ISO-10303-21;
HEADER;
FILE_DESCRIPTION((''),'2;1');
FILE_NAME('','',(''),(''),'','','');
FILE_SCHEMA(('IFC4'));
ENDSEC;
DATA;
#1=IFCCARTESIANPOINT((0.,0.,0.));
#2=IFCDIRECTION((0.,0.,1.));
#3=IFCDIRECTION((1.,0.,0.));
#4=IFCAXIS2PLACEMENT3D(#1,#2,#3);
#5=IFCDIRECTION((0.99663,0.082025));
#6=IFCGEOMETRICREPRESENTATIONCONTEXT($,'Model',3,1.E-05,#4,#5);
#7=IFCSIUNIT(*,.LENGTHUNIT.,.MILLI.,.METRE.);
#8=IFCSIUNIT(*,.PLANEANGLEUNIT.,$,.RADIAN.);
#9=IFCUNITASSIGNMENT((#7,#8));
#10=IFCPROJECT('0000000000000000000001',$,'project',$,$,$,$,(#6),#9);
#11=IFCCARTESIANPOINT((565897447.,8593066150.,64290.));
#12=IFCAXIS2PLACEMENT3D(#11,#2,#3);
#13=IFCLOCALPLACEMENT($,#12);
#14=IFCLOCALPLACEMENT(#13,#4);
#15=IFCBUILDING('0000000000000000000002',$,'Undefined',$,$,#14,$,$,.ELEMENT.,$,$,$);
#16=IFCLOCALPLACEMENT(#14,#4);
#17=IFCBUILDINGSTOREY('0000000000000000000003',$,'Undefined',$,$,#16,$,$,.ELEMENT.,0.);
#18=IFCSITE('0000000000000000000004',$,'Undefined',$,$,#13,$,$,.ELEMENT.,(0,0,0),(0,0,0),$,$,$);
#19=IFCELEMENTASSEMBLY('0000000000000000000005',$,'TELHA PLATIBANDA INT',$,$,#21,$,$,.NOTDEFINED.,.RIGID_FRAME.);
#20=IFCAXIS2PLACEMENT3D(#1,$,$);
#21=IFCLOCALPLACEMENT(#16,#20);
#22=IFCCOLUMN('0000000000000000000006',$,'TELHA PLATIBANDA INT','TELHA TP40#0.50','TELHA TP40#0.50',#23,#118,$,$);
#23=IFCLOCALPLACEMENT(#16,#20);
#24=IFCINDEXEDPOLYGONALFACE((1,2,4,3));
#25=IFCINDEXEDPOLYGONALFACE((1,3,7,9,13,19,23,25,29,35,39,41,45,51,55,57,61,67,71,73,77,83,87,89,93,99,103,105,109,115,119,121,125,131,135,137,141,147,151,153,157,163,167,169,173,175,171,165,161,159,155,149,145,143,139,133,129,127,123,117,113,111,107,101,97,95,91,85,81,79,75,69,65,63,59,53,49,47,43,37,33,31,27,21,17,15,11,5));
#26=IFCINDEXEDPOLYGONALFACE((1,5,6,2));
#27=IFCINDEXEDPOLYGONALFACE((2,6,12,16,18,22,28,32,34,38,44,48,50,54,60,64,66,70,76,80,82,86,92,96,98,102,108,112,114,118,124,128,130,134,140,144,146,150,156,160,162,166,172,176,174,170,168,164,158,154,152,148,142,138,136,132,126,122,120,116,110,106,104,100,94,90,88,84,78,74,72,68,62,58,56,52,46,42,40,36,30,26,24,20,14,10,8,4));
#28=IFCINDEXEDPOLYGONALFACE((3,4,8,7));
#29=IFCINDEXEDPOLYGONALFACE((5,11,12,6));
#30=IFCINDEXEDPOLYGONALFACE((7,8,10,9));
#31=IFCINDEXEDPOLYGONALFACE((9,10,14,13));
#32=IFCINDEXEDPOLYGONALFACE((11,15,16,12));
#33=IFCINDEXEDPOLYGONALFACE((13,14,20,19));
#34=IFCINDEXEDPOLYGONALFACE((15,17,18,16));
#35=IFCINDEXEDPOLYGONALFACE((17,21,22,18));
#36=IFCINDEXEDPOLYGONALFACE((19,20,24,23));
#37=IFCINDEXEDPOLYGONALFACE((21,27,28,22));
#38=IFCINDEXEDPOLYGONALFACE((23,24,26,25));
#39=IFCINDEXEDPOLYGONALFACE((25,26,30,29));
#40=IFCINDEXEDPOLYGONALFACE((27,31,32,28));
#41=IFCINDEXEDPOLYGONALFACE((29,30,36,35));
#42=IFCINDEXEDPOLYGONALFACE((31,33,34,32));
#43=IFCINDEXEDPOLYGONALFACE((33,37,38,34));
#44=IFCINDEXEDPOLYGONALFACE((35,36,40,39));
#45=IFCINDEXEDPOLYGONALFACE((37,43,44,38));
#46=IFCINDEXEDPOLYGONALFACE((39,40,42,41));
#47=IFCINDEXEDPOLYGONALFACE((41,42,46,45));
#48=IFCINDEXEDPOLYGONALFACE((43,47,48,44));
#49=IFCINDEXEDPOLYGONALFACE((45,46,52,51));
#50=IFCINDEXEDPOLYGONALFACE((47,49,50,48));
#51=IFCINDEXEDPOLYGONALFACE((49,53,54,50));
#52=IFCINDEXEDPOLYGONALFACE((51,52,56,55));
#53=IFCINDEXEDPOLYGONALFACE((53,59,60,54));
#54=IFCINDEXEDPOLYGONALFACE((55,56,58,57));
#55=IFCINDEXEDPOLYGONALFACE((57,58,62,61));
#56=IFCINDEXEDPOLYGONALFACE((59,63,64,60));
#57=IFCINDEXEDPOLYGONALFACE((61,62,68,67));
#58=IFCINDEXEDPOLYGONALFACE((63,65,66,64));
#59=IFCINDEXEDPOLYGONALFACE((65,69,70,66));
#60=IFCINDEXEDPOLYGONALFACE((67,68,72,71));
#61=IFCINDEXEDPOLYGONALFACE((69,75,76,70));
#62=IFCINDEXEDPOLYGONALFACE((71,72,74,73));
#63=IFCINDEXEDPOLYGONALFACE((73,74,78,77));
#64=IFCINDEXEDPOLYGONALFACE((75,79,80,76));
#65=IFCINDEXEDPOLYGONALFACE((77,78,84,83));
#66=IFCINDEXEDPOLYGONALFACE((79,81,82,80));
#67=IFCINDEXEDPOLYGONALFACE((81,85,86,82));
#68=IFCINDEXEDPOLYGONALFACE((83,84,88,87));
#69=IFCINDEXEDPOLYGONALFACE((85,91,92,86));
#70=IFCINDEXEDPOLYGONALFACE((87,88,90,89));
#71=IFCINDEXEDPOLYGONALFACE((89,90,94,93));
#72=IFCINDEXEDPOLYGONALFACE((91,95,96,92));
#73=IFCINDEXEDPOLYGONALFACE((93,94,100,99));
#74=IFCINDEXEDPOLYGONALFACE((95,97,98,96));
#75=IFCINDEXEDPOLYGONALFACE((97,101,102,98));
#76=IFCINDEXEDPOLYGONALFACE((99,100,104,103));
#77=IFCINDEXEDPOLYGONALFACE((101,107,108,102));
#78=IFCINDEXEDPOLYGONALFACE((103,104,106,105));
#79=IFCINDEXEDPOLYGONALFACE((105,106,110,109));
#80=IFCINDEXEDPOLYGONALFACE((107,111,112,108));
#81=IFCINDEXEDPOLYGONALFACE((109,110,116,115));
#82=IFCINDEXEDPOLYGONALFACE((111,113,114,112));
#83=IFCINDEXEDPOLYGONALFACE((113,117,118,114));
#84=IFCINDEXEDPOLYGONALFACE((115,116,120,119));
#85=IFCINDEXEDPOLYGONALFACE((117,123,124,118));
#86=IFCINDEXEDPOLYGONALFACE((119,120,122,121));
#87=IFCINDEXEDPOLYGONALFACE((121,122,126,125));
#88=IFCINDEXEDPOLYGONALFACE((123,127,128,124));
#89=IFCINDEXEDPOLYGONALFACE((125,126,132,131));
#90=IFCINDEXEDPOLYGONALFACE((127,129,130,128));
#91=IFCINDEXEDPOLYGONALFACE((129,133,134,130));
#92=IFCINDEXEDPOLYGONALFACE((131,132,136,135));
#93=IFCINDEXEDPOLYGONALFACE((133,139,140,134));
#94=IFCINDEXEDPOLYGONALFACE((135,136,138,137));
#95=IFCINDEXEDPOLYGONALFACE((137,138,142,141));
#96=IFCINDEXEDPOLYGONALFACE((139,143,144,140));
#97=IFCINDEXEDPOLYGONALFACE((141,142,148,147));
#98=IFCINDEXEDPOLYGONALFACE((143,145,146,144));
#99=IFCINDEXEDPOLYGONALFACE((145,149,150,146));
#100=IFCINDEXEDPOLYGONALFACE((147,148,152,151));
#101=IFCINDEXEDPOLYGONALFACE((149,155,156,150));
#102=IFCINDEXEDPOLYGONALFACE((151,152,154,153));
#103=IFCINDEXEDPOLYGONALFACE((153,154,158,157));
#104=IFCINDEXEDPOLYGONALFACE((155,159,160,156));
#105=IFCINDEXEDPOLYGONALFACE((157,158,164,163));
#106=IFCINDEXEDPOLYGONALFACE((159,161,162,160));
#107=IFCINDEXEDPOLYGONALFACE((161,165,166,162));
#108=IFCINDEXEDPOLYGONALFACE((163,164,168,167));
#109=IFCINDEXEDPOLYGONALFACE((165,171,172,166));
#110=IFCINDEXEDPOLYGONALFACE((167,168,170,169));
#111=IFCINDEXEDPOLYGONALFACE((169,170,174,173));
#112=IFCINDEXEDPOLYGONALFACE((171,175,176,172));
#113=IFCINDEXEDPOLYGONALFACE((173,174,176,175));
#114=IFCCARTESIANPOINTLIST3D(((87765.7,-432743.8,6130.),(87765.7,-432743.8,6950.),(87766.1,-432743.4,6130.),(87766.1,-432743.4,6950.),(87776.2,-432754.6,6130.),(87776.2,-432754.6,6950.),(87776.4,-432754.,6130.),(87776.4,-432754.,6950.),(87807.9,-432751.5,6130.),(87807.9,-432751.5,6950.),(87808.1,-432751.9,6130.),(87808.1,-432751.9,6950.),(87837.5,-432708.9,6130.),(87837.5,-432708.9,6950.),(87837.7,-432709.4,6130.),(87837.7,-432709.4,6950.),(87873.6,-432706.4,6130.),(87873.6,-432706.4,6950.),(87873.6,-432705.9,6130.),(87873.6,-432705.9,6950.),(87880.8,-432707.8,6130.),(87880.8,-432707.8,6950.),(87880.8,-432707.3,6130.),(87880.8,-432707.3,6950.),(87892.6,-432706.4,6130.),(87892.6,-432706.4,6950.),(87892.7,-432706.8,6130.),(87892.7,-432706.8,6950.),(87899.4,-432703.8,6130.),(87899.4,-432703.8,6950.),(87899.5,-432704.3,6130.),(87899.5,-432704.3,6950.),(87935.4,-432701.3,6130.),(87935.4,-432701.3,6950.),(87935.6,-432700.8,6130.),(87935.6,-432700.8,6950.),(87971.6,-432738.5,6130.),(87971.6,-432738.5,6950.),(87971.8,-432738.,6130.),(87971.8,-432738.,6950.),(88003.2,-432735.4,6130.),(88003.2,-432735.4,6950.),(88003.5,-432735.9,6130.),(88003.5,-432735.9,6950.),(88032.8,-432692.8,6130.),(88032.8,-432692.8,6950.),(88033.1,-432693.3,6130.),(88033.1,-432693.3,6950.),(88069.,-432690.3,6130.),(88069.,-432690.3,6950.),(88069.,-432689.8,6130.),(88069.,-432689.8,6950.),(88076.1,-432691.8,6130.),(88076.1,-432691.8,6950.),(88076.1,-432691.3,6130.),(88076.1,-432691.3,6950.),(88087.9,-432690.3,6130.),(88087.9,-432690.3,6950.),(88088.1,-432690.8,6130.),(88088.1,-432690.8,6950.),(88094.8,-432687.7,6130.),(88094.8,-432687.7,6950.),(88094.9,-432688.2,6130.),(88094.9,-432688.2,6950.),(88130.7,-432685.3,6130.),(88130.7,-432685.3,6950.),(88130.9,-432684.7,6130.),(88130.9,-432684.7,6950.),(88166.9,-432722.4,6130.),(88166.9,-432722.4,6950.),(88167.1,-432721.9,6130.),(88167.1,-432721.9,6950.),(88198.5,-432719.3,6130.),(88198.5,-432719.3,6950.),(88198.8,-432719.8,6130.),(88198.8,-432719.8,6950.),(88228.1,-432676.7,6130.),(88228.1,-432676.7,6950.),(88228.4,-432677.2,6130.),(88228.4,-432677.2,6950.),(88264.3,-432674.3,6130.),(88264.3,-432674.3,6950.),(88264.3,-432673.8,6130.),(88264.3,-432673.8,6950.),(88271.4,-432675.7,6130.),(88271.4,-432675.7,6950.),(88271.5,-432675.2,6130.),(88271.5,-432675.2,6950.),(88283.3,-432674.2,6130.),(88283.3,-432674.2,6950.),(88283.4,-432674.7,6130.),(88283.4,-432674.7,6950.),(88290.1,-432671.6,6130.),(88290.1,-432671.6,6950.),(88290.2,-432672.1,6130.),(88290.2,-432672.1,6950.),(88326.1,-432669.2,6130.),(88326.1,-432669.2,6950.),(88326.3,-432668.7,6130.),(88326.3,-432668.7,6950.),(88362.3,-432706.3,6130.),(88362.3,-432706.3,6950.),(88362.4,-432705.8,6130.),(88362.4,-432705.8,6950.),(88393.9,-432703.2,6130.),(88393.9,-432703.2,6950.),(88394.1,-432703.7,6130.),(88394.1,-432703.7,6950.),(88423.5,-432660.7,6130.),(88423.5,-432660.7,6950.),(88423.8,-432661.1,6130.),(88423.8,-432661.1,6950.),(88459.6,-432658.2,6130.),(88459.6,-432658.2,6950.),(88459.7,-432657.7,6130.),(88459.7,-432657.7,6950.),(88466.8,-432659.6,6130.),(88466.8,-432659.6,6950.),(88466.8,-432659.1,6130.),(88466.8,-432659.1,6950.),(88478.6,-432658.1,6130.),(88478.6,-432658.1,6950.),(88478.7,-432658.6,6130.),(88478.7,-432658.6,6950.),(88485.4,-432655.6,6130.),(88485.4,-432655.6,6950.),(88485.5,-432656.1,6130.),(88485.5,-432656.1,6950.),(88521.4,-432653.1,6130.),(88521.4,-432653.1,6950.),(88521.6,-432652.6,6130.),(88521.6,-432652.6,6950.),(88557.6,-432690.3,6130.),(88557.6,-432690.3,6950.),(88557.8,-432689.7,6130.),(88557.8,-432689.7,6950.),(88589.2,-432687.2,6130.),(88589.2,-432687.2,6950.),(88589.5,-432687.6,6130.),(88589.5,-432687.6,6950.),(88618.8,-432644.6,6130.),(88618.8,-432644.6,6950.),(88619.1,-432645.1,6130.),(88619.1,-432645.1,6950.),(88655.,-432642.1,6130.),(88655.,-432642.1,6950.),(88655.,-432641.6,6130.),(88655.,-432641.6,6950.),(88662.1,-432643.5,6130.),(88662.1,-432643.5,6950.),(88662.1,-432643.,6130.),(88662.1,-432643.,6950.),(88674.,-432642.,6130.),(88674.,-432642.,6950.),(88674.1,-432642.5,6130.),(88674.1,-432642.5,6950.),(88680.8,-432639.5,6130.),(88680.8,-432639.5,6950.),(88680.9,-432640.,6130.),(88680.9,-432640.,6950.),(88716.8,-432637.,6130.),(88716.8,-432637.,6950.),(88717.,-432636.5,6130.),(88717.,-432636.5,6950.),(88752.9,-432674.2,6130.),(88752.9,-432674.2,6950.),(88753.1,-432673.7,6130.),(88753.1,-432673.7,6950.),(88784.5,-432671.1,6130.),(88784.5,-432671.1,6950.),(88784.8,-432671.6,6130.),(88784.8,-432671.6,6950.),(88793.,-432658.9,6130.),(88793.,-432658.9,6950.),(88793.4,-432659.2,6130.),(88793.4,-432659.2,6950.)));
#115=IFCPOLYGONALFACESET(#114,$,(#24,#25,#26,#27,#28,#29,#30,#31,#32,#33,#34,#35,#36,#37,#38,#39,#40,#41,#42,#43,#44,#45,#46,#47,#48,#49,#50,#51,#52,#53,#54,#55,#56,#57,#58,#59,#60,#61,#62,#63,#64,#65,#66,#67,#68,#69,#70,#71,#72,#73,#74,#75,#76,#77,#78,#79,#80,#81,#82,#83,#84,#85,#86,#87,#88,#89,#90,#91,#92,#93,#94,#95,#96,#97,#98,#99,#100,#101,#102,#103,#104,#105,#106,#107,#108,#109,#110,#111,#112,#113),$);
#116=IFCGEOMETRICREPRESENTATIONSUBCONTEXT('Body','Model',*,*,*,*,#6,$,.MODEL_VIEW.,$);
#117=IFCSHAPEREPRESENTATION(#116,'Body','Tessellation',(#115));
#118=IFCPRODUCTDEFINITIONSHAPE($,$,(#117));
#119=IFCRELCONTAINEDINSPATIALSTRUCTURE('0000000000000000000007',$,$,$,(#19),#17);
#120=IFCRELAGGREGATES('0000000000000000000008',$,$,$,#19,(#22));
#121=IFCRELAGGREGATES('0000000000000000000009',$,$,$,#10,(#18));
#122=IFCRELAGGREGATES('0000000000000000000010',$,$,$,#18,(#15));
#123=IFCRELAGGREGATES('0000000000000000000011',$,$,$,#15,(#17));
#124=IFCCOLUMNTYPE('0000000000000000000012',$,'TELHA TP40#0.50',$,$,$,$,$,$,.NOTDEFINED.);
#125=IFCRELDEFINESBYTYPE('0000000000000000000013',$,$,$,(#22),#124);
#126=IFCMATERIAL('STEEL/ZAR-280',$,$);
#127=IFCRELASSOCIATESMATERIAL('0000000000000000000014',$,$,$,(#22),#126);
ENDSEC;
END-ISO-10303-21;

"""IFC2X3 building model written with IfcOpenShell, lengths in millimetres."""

from ifc_helpers import new_model, si_unit, direction, frame, origin_with_axes, place, context, subcontext, project, spatial, polyline, outline, extrude, material, type_object, element, aggregate, save


model = new_model("IFC2X3")

# Units and contexts
model_context = context("Model", 3, precision=1e-05, world=origin_with_axes(), true_north=direction((0.99663, 0.082025)))
body_context = subcontext(model_context, "Body", "Model", "MODEL_VIEW")
ifc_project = project(units=[si_unit("LENGTHUNIT", "METRE", prefix="MILLI"), si_unit("PLANEANGLEUNIT", "RADIAN")], contexts=[model_context])

# Site, building, storey
site_placement = place(None, frame((565897447.0, 8593066150.0, 64290.0), z_axis=(0.0, 0.0, 1.0), x_axis=(1.0, 0.0, 0.0)))
site = spatial("IfcSite", under=ifc_project, at=site_placement, Name="Undefined", CompositionType="ELEMENT", RefLatitude=(0, 0, 0), RefLongitude=(0, 0, 0))
building_placement = place(site_placement, origin_with_axes())
building = spatial("IfcBuilding", under=site, at=building_placement, Name="Undefined", CompositionType="ELEMENT")
storey_placement = place(building_placement, origin_with_axes())
storey = spatial("IfcBuildingStorey", under=building, at=storey_placement, Name="Undefined", CompositionType="ELEMENT", Elevation=0.0)

# Element assembly, column
ifc_material_1 = material(Name="STEEL/ZAR-280")
column_type = type_object("IfcColumnType", Name="TELHA TP40#0.50", PredefinedType="NOTDEFINED")
assembly_1_placement = place(storey_placement, origin_with_axes())
assembly_1 = element("IfcElementAssembly", 1, at=assembly_1_placement, inside=storey, Name="TELHA PLATIBANDA INT", AssemblyPlace="NOTDEFINED", PredefinedType="RIGID_FRAME")
column_1_placement = place(assembly_1_placement, frame((88279.1, -432692.9, 6130.0), z_axis=(0.0, 0.0, 1.0), x_axis=(0.082025, -0.99663, 0.0)))
column_1 = element("IfcColumn", 2, at=column_1_placement, type_object=column_type, material=ifc_material_1, Name="TELHA PLATIBANDA INT", Description="TELHA TP40#0.50", ObjectType="TELHA TP40#0.50", context=body_context, shape_type="SweptSolid", body=[
    extrude(outline(polyline([(440.8, -19.8), (473.8, 20.2), (505.8, 20.2), (515.4, 8.6), (515.0, 8.3), (505.6, 19.8), (474.0, 19.8), (441.0, -20.2), (404.7, -20.2), (397.7, -18.2), (385.9, -18.2), (378.9, -20.2), (342.6, -20.2), (309.6, 19.8), (278.0, 19.8), (245.0, -20.2), (208.7, -20.2), (201.7, -18.2), (189.9, -18.2), (182.9, -20.2), (146.6, -20.2), (113.6, 19.8), (82.0, 19.8), (49.0, -20.2), (12.7, -20.2), (5.7, -18.2), (-6.1, -18.2), (-13.1, -20.2), (-49.4, -20.2), (-82.4, 19.8), (-114.0, 19.8), (-147.0, -20.2), (-183.3, -20.2), (-190.3, -18.2), (-202.1, -18.2), (-209.1, -20.2), (-245.4, -20.2), (-278.4, 19.8), (-310.0, 19.8), (-343.0, -20.2), (-379.3, -20.2), (-386.3, -18.2), (-398.1, -18.2), (-405.1, -20.2), (-441.4, -20.2), (-474.4, 19.8), (-506.0, 19.8), (-515.4, 8.3), (-515.8, 8.6), (-506.2, 20.2), (-474.2, 20.2), (-441.2, -19.8), (-405.2, -19.8), (-398.2, -17.8), (-386.2, -17.8), (-379.2, -19.8), (-343.2, -19.8), (-310.2, 20.2), (-278.2, 20.2), (-245.2, -19.8), (-209.2, -19.8), (-202.2, -17.8), (-190.2, -17.8), (-183.2, -19.8), (-147.2, -19.8), (-114.2, 20.2), (-82.2, 20.2), (-49.2, -19.8), (-13.2, -19.8), (-6.2, -17.8), (5.8, -17.8), (12.8, -19.8), (48.8, -19.8), (81.8, 20.2), (113.8, 20.2), (146.8, -19.8), (182.8, -19.8), (189.8, -17.8), (201.8, -17.8), (208.8, -19.8), (244.8, -19.8), (277.8, 20.2), (309.8, 20.2), (342.8, -19.8), (378.8, -19.8), (385.8, -17.8), (397.8, -17.8), (404.8, -19.8), (440.8, -19.8)])), frame((0.0, 0.0, 820.0), z_axis=(0.0, 0.0, -1.0), x_axis=(0.0, 1.0, 0.0)), (0.0, 0.0, 1.0), 820.0),
])
aggregate(assembly_1, [column_1])

save(model, "model.ifc")
